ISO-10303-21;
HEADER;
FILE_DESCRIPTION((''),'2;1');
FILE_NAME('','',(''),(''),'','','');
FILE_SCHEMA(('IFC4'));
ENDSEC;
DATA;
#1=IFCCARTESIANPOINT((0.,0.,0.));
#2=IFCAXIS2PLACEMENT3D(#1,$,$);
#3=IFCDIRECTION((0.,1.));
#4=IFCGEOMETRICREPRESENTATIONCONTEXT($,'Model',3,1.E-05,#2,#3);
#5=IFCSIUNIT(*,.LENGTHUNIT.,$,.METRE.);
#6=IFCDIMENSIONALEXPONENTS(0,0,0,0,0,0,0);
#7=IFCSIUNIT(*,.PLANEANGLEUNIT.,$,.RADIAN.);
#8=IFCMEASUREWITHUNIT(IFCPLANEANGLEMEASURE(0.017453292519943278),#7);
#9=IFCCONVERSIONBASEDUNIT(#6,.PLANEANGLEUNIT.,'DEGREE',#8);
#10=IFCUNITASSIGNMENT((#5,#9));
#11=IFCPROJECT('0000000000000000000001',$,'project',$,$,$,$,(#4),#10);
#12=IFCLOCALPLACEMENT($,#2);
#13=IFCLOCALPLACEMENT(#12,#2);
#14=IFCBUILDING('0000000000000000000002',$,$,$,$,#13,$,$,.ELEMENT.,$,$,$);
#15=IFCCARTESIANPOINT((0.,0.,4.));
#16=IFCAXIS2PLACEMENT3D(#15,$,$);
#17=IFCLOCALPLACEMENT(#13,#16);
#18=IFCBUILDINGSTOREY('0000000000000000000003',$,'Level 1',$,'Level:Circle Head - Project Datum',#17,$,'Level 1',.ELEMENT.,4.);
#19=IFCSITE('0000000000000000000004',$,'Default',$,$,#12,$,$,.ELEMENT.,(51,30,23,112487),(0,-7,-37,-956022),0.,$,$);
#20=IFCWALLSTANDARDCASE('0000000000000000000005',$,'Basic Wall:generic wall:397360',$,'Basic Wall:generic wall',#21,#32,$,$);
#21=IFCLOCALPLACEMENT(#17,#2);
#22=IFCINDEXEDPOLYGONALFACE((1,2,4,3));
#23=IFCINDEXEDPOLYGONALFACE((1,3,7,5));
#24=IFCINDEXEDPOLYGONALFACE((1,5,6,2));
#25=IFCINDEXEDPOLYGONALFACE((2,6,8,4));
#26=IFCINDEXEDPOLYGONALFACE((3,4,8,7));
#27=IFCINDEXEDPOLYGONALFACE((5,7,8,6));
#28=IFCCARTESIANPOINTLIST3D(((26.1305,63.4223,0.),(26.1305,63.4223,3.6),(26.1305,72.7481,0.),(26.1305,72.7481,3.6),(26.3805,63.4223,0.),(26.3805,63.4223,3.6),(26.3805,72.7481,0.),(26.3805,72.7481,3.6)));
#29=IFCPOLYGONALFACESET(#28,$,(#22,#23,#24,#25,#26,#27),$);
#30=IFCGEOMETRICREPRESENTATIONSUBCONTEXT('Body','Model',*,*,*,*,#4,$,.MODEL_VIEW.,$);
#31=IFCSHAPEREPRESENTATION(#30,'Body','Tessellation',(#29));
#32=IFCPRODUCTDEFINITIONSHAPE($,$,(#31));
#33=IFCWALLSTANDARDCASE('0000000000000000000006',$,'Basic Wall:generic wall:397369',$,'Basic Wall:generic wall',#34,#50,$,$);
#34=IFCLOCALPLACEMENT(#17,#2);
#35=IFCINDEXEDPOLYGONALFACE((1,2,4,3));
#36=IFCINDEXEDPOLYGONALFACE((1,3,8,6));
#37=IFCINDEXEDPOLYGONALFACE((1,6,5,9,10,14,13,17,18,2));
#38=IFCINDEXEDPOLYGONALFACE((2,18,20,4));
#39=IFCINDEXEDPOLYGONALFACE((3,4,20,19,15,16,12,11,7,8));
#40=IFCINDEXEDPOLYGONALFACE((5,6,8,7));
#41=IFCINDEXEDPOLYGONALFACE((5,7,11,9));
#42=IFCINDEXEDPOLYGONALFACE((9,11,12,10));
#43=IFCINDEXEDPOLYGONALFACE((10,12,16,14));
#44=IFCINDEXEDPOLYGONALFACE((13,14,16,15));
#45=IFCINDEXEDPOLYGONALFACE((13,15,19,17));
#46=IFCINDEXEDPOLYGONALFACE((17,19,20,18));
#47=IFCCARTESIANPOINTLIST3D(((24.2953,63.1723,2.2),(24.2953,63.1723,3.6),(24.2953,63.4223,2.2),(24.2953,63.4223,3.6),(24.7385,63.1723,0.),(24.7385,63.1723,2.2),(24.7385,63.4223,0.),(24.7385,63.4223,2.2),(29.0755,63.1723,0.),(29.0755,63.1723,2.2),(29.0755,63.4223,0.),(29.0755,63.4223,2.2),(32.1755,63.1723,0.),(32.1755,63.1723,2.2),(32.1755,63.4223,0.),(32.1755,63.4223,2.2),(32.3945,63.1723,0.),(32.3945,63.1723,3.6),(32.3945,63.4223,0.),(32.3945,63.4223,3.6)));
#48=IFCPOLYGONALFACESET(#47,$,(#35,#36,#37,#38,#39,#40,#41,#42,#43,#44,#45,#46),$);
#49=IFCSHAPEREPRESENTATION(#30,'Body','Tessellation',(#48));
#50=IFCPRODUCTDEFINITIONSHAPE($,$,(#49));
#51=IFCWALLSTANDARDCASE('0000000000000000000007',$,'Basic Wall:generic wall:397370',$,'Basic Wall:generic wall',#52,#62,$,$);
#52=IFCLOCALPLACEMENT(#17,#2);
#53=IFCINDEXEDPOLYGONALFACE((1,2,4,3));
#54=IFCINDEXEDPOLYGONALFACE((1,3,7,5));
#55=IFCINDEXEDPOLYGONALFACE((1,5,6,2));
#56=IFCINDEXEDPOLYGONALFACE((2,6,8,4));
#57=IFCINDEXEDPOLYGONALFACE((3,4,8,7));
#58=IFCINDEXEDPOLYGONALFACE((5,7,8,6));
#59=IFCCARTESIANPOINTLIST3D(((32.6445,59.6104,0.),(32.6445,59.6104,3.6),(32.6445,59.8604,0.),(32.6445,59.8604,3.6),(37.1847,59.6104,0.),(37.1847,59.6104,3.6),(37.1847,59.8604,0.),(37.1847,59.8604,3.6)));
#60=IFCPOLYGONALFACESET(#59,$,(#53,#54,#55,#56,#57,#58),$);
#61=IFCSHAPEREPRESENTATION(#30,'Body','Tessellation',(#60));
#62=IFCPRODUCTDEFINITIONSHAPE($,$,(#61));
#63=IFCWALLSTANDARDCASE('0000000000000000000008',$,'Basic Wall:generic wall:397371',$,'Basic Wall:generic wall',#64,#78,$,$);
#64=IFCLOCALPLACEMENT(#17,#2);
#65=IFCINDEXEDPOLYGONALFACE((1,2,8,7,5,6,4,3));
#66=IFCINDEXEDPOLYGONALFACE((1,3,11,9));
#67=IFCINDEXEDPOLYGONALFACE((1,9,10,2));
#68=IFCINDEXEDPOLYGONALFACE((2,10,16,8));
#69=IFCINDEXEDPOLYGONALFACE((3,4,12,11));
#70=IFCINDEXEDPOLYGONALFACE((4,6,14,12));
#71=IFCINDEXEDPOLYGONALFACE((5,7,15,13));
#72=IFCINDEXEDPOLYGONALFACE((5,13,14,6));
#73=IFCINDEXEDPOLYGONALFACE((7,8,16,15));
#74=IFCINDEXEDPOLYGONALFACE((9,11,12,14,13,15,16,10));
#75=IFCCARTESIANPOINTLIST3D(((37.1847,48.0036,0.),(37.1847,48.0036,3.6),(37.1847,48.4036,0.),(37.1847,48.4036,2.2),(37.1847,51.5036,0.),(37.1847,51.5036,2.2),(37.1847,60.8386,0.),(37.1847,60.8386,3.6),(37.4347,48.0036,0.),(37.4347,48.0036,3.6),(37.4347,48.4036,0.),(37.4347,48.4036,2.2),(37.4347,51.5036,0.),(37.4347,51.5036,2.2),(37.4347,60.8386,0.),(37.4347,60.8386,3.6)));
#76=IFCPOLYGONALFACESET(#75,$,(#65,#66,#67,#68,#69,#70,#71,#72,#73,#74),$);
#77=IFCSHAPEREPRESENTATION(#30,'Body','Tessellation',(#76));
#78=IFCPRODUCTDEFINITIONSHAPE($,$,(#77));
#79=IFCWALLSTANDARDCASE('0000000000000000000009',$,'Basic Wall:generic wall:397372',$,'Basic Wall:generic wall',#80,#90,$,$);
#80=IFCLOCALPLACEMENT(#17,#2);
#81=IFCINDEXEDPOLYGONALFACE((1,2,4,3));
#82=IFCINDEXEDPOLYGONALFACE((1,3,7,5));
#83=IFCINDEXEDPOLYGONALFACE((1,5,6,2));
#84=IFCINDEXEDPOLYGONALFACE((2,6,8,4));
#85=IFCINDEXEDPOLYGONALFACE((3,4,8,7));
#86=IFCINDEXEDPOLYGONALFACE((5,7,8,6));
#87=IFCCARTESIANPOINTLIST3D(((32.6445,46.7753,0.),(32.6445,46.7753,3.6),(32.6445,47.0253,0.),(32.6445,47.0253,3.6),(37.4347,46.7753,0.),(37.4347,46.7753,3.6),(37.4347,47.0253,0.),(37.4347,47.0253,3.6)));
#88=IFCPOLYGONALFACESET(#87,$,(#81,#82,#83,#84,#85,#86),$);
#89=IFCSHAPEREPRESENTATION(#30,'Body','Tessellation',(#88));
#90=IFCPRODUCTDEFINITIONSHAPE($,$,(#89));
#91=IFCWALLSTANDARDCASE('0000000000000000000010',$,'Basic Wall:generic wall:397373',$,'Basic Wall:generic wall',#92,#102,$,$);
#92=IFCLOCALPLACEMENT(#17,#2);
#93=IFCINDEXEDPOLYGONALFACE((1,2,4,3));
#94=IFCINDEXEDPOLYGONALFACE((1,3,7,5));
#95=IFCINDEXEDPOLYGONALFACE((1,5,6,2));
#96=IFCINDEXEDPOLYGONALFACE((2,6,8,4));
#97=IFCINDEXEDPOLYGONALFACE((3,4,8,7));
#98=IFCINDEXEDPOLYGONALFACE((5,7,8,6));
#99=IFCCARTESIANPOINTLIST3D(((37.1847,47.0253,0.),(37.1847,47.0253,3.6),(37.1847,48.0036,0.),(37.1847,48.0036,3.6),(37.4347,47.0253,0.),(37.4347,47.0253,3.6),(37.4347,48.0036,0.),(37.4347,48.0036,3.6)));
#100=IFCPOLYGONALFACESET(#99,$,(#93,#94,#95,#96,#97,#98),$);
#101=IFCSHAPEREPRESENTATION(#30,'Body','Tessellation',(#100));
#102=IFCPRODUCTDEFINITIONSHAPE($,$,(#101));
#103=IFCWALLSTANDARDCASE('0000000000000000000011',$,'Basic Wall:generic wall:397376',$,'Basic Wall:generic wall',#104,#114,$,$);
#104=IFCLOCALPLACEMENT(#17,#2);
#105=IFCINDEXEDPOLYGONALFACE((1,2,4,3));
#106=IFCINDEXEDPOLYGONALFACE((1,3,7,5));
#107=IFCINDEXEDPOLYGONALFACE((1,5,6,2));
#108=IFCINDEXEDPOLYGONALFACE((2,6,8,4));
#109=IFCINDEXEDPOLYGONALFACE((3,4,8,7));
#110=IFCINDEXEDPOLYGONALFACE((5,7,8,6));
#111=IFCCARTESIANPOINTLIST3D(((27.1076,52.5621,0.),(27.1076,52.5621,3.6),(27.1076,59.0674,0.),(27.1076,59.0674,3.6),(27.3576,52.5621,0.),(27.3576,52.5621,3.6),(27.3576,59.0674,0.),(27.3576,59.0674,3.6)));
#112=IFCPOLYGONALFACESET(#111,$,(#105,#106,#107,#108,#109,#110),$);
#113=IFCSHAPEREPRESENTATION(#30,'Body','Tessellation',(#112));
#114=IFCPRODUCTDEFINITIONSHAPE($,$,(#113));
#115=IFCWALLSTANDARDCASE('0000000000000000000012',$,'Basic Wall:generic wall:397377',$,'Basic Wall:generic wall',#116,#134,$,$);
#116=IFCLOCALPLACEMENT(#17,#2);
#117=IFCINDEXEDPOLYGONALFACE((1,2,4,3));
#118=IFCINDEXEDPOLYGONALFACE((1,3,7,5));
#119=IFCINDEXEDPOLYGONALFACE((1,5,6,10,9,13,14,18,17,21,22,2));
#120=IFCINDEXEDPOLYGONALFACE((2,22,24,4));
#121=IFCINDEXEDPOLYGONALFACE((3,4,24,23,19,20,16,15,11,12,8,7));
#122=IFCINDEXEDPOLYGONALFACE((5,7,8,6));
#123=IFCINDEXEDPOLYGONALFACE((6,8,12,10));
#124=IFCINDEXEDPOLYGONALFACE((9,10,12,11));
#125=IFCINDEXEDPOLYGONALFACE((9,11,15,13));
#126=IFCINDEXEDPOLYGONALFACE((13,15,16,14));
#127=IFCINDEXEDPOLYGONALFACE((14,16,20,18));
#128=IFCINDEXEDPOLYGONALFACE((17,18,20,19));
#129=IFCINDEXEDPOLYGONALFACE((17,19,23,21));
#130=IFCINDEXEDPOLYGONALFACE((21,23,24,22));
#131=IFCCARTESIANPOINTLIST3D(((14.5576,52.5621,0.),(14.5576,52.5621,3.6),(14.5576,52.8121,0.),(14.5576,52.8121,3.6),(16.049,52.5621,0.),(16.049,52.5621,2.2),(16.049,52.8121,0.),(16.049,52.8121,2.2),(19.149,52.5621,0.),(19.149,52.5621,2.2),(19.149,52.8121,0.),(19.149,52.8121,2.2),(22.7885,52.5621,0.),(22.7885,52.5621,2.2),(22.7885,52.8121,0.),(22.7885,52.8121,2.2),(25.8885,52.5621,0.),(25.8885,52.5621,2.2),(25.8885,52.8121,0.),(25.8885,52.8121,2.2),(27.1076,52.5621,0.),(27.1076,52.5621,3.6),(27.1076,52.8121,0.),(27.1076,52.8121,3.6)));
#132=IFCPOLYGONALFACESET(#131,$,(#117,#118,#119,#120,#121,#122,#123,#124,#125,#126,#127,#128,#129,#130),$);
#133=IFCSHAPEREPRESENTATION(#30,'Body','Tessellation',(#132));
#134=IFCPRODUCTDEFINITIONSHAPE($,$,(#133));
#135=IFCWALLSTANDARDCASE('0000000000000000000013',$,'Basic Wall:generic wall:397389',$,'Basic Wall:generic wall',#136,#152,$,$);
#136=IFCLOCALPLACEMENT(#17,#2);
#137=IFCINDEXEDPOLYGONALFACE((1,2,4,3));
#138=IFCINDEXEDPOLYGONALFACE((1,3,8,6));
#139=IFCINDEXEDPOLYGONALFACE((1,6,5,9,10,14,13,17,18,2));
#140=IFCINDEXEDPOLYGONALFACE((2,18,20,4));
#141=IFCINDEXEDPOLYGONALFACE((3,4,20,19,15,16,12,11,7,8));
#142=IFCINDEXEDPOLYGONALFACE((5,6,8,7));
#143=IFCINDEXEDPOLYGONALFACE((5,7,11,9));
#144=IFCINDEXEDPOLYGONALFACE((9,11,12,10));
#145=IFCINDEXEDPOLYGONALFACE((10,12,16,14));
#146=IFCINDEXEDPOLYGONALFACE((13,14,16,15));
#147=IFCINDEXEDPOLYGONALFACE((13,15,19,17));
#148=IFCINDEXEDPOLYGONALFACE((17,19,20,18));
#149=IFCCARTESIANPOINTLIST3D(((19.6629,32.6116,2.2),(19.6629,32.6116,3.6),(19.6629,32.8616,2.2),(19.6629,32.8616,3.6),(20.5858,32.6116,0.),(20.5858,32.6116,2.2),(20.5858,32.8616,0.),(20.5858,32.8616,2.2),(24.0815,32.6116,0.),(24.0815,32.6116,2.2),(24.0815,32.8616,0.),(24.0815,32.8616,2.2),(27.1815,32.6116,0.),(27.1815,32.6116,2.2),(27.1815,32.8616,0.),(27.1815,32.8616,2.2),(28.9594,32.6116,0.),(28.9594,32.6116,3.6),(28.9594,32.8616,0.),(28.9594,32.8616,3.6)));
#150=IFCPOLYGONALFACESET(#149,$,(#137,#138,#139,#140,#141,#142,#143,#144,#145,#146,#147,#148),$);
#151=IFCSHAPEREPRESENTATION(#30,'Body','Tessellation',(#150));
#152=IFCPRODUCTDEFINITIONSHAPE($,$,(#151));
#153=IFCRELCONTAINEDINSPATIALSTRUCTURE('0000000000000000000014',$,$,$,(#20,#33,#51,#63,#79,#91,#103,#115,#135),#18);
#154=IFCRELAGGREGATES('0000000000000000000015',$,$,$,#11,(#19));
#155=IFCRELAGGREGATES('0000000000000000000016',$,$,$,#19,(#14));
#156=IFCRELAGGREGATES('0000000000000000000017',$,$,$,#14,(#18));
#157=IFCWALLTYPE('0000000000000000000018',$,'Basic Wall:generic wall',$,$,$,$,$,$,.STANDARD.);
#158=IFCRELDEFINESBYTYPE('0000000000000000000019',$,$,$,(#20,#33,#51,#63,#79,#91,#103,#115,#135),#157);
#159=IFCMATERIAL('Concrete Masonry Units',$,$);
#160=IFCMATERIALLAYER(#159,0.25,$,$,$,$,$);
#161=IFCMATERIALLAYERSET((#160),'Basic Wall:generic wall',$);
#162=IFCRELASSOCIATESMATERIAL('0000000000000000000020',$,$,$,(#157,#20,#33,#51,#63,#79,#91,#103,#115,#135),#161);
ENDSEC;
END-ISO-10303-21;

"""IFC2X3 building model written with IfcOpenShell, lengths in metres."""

from ifc_helpers import new_model, entity, si_unit, converted_unit, direction, frame, frame_2d, origin, origin_2d_with_axis, place, context, subcontext, project, spatial, rectangle, extrude, material, layer, layer_set, layer_usage, type_object, element, save


model = new_model("IFC2X3")

# Units and contexts
model_context = context("Model", 3, precision=1e-05, world=origin(), true_north=direction((0.0, 1.0)))
body_context = subcontext(model_context, "Body", "Model", "MODEL_VIEW")
ifc_project = project(units=[si_unit("LENGTHUNIT", "METRE"), converted_unit("PLANEANGLEUNIT", "DEGREE", entity("IfcPlaneAngleMeasure", 0.017453292519943278), si_unit("PLANEANGLEUNIT", "RADIAN"), dimensions=[0, 0, 0, 0, 0, 0, 0])], contexts=[model_context])

# Site, building, storey
site_placement = place(None, origin())
site = spatial("IfcSite", under=ifc_project, at=site_placement, Name="Default", CompositionType="ELEMENT", RefLatitude=(51, 30, 23, 112487), RefLongitude=(0, -7, -37, -956022), RefElevation=0.0)
building_placement = place(site_placement, origin())
building = spatial("IfcBuilding", under=site, at=building_placement, CompositionType="ELEMENT")
storey_placement = place(building_placement, frame((0.0, 0.0, 4.0)))
storey = spatial("IfcBuildingStorey", under=building, at=storey_placement, Name="Level 1", ObjectType="Level:Circle Head - Project Datum", LongName="Level 1", CompositionType="ELEMENT", Elevation=4.0)

# Shared definitions
ifc_material = material(Name="Concrete Masonry Units")
ifc_layer = layer(ifc_material, 0.25)
ifc_layer_set = layer_set([ifc_layer], Name="Basic Wall:generic wall")
wall_type = type_object("IfcWallType", Name="Basic Wall:generic wall", PredefinedType="STANDARD", material=ifc_layer_set)

# Wall
ifc_layer_usage_1 = layer_usage(ifc_layer_set, "AXIS2", "NEGATIVE", 0.125)
wall_1_placement = place(storey_placement, frame((26.2555, 72.7481, 0.0), z_axis=(0.0, 0.0, 1.0), x_axis=(0.0, -1.0, 0.0)))
element("IfcWallStandardCase", 1, at=wall_1_placement, inside=storey, type_object=wall_type, material=ifc_layer_usage_1, Name="Basic Wall:generic wall:397360", ObjectType="Basic Wall:generic wall", context=body_context, shape_type="SweptSolid", body=[
    extrude(rectangle(XDim=9.3259, YDim=0.25, at=frame_2d((4.6629, 0.0), x_axis=(-1.0, 0.0))), origin(), (0.0, 0.0, 1.0), 3.6),
])

# Wall, openings
ifc_layer_usage_2 = layer_usage(ifc_layer_set, "AXIS2", "NEGATIVE", 0.125)
wall_2_placement = place(storey_placement, frame((32.3945, 63.2973, 0.0), z_axis=(0.0, 0.0, 1.0), x_axis=(-1.0, 0.0, 0.0)))
wall_2 = element("IfcWallStandardCase", 2, at=wall_2_placement, inside=storey, type_object=wall_type, material=ifc_layer_usage_2, Name="Basic Wall:generic wall:397369", ObjectType="Basic Wall:generic wall", context=body_context, shape_type="SweptSolid", body=[
    extrude(rectangle(XDim=8.0993, YDim=0.25, at=frame_2d((4.0496, 0.0), x_axis=(1.0, 0.0))), origin(), (0.0, 0.0, 1.0), 3.6),
])
opening_1_placement = place(wall_2_placement, origin())
element("IfcOpeningElement", 3, at=opening_1_placement, cuts=wall_2, ObjectType="Opening", context=body_context, shape_type="SweptSolid", body=[
    extrude(rectangle(XDim=2.2, YDim=3.1, at=origin_2d_with_axis()), frame((9.206, -1.399, 1.1), z_axis=(0.0, 1.0, 0.0), x_axis=(0.0, 0.0, 1.0)), (0.0, 0.0, 1.0), 3.048),
])
opening_2_placement = place(wall_2_placement, frame((3.3191, 0.125, 0.0)))
element("IfcOpeningElement", 4, at=opening_2_placement, cuts=wall_2, ObjectType="Opening", context=body_context, shape_type="SweptSolid", body=[
    extrude(rectangle(XDim=2.2, YDim=3.1, at=frame_2d((1.1, 1.55), x_axis=(1.0, 0.0))), frame((0.0, 0.0, 0.0), z_axis=(0.0, -1.0, 0.0), x_axis=(0.0, 0.0, 1.0)), (0.0, 0.0, 1.0), 0.25),
])

# Wall
ifc_layer_usage_3 = layer_usage(ifc_layer_set, "AXIS2", "NEGATIVE", 0.125)
wall_3_placement = place(storey_placement, frame((37.1847, 59.7354, 0.0), z_axis=(0.0, 0.0, 1.0), x_axis=(-1.0, 0.0, 0.0)))
element("IfcWallStandardCase", 5, at=wall_3_placement, inside=storey, type_object=wall_type, material=ifc_layer_usage_3, Name="Basic Wall:generic wall:397370", ObjectType="Basic Wall:generic wall", context=body_context, shape_type="SweptSolid", body=[
    extrude(rectangle(XDim=4.5401, YDim=0.25, at=frame_2d((2.2701, 0.0), x_axis=(-1.0, 0.0))), origin(), (0.0, 0.0, 1.0), 3.6),
])

# Wall, opening
ifc_layer_usage_4 = layer_usage(ifc_layer_set, "AXIS2", "NEGATIVE", 0.125)
wall_4_placement = place(storey_placement, frame((37.3097, 48.0036, 0.0), z_axis=(0.0, 0.0, 1.0), x_axis=(0.0, 1.0, 0.0)))
wall_4 = element("IfcWallStandardCase", 6, at=wall_4_placement, inside=storey, type_object=wall_type, material=ifc_layer_usage_4, Name="Basic Wall:generic wall:397371", ObjectType="Basic Wall:generic wall", context=body_context, shape_type="SweptSolid", body=[
    extrude(rectangle(XDim=12.8351, YDim=0.25, at=frame_2d((6.4175, 0.0), x_axis=(-1.0, 0.0))), origin(), (0.0, 0.0, 1.0), 3.6),
])
opening_3_placement = place(wall_4_placement, frame((0.4, -0.125, 0.0)))
element("IfcOpeningElement", 7, at=opening_3_placement, cuts=wall_4, ObjectType="Opening", context=body_context, shape_type="SweptSolid", body=[
    extrude(rectangle(XDim=2.2, YDim=3.1, at=frame_2d((1.1, 1.55), x_axis=(1.0, 0.0))), frame((0.0, 0.0, 0.0), z_axis=(0.0, 1.0, 0.0), x_axis=(0.0, 0.0, 1.0)), (0.0, 0.0, 1.0), 0.25),
])

# Walls
ifc_layer_usage_5 = layer_usage(ifc_layer_set, "AXIS2", "NEGATIVE", 0.125)
wall_5_placement = place(storey_placement, frame((37.4347, 46.9003, 0.0), z_axis=(0.0, 0.0, 1.0), x_axis=(-1.0, 0.0, 0.0)))
element("IfcWallStandardCase", 8, at=wall_5_placement, inside=storey, type_object=wall_type, material=ifc_layer_usage_5, Name="Basic Wall:generic wall:397372", ObjectType="Basic Wall:generic wall", context=body_context, shape_type="SweptSolid", body=[
    extrude(rectangle(XDim=4.7901, YDim=0.25, at=frame_2d((2.3951, 0.0), x_axis=(-1.0, 0.0))), origin(), (0.0, 0.0, 1.0), 3.6),
])
ifc_layer_usage_6 = layer_usage(ifc_layer_set, "AXIS2", "NEGATIVE", 0.125)
wall_6_placement = place(storey_placement, frame((37.3097, 48.0036, 0.0), z_axis=(0.0, 0.0, 1.0), x_axis=(0.0, -1.0, 0.0)))
element("IfcWallStandardCase", 9, at=wall_6_placement, inside=storey, type_object=wall_type, material=ifc_layer_usage_6, Name="Basic Wall:generic wall:397373", ObjectType="Basic Wall:generic wall", context=body_context, shape_type="SweptSolid", body=[
    extrude(rectangle(XDim=0.9782, YDim=0.25, at=frame_2d((0.4891, 0.0), x_axis=(-1.0, 0.0))), origin(), (0.0, 0.0, 1.0), 3.6),
])
ifc_layer_usage_7 = layer_usage(ifc_layer_set, "AXIS2", "NEGATIVE", 0.125)
wall_7_placement = place(storey_placement, frame((27.2326, 59.0674, 0.0), z_axis=(0.0, 0.0, 1.0), x_axis=(0.0, -1.0, 0.0)))
element("IfcWallStandardCase", 10, at=wall_7_placement, inside=storey, type_object=wall_type, material=ifc_layer_usage_7, Name="Basic Wall:generic wall:397376", ObjectType="Basic Wall:generic wall", context=body_context, shape_type="SweptSolid", body=[
    extrude(rectangle(XDim=6.5053, YDim=0.25, at=frame_2d((3.2526, 0.0), x_axis=(-1.0, 0.0))), origin(), (0.0, 0.0, 1.0), 3.6),
])

# Walls, openings
ifc_layer_usage_8 = layer_usage(ifc_layer_set, "AXIS2", "NEGATIVE", 0.125)
wall_8_placement = place(storey_placement, frame((27.1076, 52.6871, 0.0), z_axis=(0.0, 0.0, 1.0), x_axis=(-1.0, 0.0, 0.0)))
wall_8 = element("IfcWallStandardCase", 11, at=wall_8_placement, inside=storey, type_object=wall_type, material=ifc_layer_usage_8, Name="Basic Wall:generic wall:397377", ObjectType="Basic Wall:generic wall", context=body_context, shape_type="SweptSolid", body=[
    extrude(rectangle(XDim=12.55, YDim=0.25, at=frame_2d((6.275, 0.0), x_axis=(1.0, 0.0))), origin(), (0.0, 0.0, 1.0), 3.6),
])
opening_4_placement = place(wall_8_placement, frame((11.0586, 0.125, 0.0)))
element("IfcOpeningElement", 12, at=opening_4_placement, cuts=wall_8, ObjectType="Opening", context=body_context, shape_type="SweptSolid", body=[
    extrude(rectangle(XDim=2.2, YDim=3.1, at=frame_2d((1.1, 1.55), x_axis=(1.0, 0.0))), frame((0.0, 0.0, 0.0), z_axis=(0.0, -1.0, 0.0), x_axis=(0.0, 0.0, 1.0)), (0.0, 0.0, 1.0), 0.25),
])
opening_5_placement = place(wall_8_placement, frame((4.319, 0.125, 0.0)))
element("IfcOpeningElement", 13, at=opening_5_placement, cuts=wall_8, ObjectType="Opening", context=body_context, shape_type="SweptSolid", body=[
    extrude(rectangle(XDim=2.2, YDim=3.1, at=frame_2d((1.1, 1.55), x_axis=(1.0, 0.0))), frame((0.0, 0.0, 0.0), z_axis=(0.0, -1.0, 0.0), x_axis=(0.0, 0.0, 1.0)), (0.0, 0.0, 1.0), 0.25),
])
ifc_layer_usage_9 = layer_usage(ifc_layer_set, "AXIS2", "NEGATIVE", 0.125)
wall_9_placement = place(storey_placement, frame((28.9594, 32.7366, 0.0), z_axis=(0.0, 0.0, 1.0), x_axis=(-1.0, 0.0, 0.0)))
wall_9 = element("IfcWallStandardCase", 14, at=wall_9_placement, inside=storey, type_object=wall_type, material=ifc_layer_usage_9, Name="Basic Wall:generic wall:397389", ObjectType="Basic Wall:generic wall", context=body_context, shape_type="SweptSolid", body=[
    extrude(rectangle(XDim=9.2965, YDim=0.25, at=frame_2d((4.6483, 0.0), x_axis=(-1.0, 0.0))), origin(), (0.0, 0.0, 1.0), 3.6),
])
opening_6_placement = place(wall_9_placement, origin())
element("IfcOpeningElement", 15, at=opening_6_placement, cuts=wall_9, ObjectType="Opening", context=body_context, shape_type="SweptSolid", body=[
    extrude(rectangle(XDim=2.2, YDim=3.1, at=frame_2d((0.0, 0.0), x_axis=(1.0, 0.0))), frame((9.9236, -1.399, 1.1), z_axis=(0.0, 1.0, 0.0), x_axis=(0.0, 0.0, 1.0)), (0.0, 0.0, 1.0), 3.048),
])
opening_7_placement = place(wall_9_placement, frame((4.8779, 0.125, 0.0)))
element("IfcOpeningElement", 16, at=opening_7_placement, cuts=wall_9, ObjectType="Opening", context=body_context, shape_type="SweptSolid", body=[
    extrude(rectangle(XDim=2.2, YDim=3.1, at=frame_2d((1.1, 1.55), x_axis=(1.0, 0.0))), frame((0.0, 0.0, 0.0), z_axis=(0.0, -1.0, 0.0), x_axis=(0.0, 0.0, 1.0)), (0.0, 0.0, 1.0), 0.25),
])

save(model, "model.ifc")
